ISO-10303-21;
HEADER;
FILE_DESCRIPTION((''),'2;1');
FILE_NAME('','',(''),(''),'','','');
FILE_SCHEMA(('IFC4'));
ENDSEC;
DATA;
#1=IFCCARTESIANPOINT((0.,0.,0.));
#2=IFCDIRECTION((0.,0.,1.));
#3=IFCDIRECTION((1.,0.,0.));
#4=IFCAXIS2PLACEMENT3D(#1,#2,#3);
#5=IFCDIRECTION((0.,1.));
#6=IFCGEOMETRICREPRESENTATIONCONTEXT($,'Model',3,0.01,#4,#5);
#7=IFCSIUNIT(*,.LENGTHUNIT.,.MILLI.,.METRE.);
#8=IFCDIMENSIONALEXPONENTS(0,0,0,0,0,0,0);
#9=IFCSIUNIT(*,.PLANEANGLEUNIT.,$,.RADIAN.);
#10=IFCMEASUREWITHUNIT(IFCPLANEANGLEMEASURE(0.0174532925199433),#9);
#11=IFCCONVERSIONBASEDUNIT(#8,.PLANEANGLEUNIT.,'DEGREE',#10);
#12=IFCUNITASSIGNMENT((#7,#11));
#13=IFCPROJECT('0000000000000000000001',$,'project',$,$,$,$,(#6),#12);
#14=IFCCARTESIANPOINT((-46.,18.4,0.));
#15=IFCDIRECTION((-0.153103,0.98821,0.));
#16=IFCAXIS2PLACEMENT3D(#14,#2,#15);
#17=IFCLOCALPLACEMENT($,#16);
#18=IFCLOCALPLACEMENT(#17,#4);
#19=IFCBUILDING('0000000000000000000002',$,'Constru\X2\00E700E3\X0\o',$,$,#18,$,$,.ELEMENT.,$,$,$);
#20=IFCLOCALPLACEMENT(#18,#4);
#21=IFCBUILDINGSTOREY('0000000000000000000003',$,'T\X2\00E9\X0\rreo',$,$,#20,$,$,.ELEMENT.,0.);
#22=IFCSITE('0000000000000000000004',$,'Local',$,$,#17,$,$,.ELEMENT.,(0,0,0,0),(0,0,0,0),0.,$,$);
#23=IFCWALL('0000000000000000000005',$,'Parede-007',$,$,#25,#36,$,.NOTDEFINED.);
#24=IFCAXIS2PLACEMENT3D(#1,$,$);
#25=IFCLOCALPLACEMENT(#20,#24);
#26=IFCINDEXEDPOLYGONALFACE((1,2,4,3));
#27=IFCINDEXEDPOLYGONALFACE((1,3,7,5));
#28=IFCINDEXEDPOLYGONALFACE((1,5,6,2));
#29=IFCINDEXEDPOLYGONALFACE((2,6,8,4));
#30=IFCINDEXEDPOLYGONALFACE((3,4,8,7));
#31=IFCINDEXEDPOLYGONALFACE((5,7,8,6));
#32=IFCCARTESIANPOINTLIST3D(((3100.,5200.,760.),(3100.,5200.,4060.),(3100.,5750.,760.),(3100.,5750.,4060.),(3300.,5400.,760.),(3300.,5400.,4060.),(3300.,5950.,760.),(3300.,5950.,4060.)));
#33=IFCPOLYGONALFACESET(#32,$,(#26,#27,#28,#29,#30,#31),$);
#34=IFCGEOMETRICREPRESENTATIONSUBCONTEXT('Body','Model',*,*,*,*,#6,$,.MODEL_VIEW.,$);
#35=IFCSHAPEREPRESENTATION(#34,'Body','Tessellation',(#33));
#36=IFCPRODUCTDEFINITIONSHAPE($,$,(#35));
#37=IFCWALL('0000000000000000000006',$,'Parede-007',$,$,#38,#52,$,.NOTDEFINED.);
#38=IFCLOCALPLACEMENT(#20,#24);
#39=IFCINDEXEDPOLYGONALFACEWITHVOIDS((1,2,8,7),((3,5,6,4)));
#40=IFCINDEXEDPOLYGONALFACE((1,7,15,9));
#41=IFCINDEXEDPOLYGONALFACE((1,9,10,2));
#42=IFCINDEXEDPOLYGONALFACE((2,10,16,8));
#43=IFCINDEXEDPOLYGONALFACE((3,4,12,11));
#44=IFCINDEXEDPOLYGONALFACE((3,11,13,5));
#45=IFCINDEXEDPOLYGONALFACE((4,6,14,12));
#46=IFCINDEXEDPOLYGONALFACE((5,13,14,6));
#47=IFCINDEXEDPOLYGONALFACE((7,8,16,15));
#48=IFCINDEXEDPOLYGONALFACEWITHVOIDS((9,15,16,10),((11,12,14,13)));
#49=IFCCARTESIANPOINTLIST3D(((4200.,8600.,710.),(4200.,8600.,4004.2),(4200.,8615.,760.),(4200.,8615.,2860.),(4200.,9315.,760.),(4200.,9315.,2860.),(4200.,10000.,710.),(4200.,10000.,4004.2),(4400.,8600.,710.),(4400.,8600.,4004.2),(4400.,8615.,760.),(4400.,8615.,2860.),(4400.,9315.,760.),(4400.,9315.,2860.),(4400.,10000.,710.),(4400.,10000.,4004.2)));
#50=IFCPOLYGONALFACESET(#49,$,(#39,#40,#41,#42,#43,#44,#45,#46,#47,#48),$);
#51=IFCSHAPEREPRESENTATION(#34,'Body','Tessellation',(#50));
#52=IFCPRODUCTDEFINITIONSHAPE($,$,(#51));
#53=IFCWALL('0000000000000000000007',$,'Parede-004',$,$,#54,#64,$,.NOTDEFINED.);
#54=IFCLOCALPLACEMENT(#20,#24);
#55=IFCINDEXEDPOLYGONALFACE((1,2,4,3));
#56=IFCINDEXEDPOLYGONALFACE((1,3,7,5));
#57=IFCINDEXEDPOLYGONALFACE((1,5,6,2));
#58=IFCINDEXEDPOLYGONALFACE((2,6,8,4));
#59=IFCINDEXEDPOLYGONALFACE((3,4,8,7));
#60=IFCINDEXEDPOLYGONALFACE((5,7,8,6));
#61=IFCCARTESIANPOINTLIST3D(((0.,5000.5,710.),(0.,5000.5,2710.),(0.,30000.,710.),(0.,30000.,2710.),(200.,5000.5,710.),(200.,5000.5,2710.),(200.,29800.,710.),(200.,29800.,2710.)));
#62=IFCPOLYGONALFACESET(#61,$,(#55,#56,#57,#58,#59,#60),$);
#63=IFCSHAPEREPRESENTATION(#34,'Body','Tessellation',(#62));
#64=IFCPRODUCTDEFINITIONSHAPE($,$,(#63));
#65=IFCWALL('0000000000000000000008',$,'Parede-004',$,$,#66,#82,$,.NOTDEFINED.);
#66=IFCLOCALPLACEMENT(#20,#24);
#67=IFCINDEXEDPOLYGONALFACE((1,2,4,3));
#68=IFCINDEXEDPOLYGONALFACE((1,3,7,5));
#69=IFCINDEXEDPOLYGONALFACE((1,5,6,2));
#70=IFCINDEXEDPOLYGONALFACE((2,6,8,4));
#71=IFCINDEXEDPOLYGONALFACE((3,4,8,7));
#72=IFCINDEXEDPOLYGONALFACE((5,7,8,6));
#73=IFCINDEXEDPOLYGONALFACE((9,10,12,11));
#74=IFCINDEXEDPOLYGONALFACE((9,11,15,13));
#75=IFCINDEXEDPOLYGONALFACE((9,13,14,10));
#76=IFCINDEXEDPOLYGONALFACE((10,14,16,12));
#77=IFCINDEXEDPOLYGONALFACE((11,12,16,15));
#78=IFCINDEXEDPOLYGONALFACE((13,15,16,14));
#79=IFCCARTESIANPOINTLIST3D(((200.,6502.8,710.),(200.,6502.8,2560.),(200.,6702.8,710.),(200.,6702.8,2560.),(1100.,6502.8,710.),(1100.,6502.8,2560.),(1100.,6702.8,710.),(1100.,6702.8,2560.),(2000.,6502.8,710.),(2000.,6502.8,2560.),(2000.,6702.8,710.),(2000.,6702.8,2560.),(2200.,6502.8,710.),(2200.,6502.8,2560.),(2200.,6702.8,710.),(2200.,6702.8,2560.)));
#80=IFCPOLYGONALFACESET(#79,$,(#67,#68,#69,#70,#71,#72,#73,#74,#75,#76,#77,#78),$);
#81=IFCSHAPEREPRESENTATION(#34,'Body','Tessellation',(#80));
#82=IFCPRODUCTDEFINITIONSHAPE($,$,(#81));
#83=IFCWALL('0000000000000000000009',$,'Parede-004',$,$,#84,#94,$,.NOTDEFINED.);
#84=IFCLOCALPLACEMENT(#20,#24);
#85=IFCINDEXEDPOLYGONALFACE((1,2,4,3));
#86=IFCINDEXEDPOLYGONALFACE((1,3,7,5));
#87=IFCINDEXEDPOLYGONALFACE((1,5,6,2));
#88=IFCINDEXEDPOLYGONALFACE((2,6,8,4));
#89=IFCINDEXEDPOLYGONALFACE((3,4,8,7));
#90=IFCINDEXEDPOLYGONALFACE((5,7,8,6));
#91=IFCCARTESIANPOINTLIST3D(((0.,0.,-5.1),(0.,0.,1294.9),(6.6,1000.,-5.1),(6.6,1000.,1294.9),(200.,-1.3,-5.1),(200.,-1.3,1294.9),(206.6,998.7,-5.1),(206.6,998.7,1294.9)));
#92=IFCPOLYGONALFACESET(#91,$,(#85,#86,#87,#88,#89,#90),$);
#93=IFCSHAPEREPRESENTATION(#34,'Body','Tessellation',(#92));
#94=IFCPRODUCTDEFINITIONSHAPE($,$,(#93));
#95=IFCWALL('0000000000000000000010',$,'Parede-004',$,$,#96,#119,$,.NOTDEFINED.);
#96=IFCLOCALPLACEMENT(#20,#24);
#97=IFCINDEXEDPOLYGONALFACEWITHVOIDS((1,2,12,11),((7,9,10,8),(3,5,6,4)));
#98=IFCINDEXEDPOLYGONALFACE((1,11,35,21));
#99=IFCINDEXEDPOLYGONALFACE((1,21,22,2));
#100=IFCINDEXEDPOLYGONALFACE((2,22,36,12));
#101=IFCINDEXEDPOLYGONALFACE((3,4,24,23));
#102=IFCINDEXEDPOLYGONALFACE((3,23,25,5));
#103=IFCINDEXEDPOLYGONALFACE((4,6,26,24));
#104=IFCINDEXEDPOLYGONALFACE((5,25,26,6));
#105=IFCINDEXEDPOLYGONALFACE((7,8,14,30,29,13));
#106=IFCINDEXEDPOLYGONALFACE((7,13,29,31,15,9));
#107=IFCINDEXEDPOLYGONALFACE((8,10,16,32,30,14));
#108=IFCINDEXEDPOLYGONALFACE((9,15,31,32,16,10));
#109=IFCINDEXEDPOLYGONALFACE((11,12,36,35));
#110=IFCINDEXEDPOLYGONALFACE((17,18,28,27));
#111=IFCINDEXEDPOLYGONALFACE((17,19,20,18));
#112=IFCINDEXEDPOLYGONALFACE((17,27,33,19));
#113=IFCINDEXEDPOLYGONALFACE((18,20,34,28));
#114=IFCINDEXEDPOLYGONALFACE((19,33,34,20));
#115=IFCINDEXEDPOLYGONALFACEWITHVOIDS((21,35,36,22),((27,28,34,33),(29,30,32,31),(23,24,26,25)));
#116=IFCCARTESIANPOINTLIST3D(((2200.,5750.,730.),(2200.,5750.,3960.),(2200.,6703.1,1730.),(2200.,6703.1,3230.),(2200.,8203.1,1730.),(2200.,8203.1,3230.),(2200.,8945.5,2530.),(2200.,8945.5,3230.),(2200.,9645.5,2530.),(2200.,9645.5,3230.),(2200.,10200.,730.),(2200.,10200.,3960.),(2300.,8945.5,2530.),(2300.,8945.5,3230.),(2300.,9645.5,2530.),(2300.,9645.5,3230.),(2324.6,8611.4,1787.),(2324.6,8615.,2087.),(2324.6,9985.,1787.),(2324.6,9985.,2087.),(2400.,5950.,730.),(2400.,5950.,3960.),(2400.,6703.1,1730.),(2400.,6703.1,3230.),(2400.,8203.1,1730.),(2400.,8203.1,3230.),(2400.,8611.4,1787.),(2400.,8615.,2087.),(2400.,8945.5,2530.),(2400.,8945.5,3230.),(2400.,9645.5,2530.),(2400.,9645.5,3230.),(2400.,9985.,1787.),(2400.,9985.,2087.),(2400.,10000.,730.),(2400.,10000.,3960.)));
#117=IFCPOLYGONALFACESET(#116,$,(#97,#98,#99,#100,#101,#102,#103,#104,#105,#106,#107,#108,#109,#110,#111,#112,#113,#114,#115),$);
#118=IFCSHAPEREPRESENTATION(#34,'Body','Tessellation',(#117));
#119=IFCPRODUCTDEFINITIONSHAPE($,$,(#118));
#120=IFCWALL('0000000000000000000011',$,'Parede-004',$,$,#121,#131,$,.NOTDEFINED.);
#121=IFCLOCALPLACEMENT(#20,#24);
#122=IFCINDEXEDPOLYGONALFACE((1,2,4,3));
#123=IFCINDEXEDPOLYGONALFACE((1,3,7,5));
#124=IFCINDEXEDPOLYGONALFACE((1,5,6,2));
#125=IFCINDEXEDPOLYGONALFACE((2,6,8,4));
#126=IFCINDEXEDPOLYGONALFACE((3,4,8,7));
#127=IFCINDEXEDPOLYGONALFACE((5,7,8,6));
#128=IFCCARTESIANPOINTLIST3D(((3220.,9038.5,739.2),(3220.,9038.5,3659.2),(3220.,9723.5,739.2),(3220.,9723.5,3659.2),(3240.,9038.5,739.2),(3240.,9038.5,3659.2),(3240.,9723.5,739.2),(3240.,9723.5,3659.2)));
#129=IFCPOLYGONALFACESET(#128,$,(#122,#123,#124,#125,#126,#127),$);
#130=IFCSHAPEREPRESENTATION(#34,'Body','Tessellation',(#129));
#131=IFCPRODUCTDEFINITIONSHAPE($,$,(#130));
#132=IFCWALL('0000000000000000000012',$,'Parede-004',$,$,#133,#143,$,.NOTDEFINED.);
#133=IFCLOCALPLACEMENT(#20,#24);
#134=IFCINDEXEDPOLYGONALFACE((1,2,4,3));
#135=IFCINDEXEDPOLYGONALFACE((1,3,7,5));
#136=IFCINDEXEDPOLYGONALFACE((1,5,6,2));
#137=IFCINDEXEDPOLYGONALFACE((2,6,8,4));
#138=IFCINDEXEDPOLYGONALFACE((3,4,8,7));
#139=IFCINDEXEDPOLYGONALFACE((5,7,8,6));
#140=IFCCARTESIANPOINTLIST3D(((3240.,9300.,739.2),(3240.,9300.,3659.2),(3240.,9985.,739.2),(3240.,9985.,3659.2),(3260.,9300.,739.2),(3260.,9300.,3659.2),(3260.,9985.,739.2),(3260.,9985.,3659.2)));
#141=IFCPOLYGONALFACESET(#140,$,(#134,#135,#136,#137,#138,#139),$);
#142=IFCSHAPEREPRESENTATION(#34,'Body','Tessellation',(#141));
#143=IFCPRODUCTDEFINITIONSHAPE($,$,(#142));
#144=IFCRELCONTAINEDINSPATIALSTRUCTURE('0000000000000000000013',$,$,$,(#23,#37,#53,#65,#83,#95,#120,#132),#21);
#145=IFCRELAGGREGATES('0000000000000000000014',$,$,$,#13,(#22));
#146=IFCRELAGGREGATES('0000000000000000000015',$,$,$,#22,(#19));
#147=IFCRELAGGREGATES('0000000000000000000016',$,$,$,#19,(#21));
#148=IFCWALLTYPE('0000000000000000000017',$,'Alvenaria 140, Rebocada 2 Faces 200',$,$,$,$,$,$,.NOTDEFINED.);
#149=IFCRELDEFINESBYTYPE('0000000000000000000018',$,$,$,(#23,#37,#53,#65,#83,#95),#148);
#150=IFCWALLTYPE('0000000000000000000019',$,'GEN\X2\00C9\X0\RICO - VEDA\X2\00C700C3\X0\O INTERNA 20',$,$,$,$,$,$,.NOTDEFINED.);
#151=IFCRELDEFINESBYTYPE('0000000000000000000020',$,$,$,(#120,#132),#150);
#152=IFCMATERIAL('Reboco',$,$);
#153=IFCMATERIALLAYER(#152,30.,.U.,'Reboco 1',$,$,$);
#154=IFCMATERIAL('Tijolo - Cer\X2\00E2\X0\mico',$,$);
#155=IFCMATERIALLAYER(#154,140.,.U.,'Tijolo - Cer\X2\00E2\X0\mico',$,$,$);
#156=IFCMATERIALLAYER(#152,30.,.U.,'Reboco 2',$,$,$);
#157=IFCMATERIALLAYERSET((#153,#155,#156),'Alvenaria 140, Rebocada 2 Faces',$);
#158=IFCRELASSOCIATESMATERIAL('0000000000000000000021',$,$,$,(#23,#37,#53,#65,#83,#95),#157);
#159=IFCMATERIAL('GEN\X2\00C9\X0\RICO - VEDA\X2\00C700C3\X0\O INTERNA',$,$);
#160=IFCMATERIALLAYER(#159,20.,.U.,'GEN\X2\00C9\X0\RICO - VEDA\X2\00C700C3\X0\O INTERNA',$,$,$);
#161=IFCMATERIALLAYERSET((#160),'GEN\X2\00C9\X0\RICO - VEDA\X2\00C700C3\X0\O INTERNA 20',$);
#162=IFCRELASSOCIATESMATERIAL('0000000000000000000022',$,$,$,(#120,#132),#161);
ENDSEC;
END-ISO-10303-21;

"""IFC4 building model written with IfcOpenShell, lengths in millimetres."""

from ifc_helpers import new_model, entity, si_unit, converted_unit, direction, frame, origin_with_axes, origin_2d_with_axis, place, context, subcontext, project, spatial, line, indexed_curve, rectangle, outline, extrude, material, layer, layer_set, layer_usage, type_object, element, save


model = new_model("IFC4")

# Units and contexts
model_context = context("Model", 3, precision=0.01, world=origin_with_axes(), true_north=direction((0.0, 1.0)))
body_context = subcontext(model_context, "Body", "Model", "MODEL_VIEW")
ifc_project = project(units=[si_unit("LENGTHUNIT", "METRE", prefix="MILLI"), converted_unit("PLANEANGLEUNIT", "DEGREE", entity("IfcPlaneAngleMeasure", 0.0174532925199433), si_unit("PLANEANGLEUNIT", "RADIAN"), dimensions=[0, 0, 0, 0, 0, 0, 0])], contexts=[model_context])

# Site, building, storey
site_placement = place(None, frame((-46.0, 18.4, 0.0), z_axis=(0.0, 0.0, 1.0), x_axis=(-0.153103, 0.98821, 0.0)))
site = spatial("IfcSite", under=ifc_project, at=site_placement, Name="Local", CompositionType="ELEMENT", RefLatitude=(0, 0, 0, 0), RefLongitude=(0, 0, 0, 0), RefElevation=0.0)
building_placement = place(site_placement, origin_with_axes())
building = spatial("IfcBuilding", under=site, at=building_placement, Name="Construção", CompositionType="ELEMENT")
storey_placement = place(building_placement, origin_with_axes())
storey = spatial("IfcBuildingStorey", under=building, at=storey_placement, Name="Térreo", CompositionType="ELEMENT", Elevation=0.0)

# Wall
ifc_material_1 = material(Name="Reboco")
ifc_layer_1 = layer(ifc_material_1, 30.0, ventilated="UNKNOWN", Name="Reboco 1")
ifc_material_2 = material(Name="Tijolo - Cerâmico")
ifc_layer_2 = layer(ifc_material_2, 140.0, ventilated="UNKNOWN", Name="Tijolo - Cerâmico")
ifc_layer_3 = layer(ifc_material_1, 30.0, ventilated="UNKNOWN", Name="Reboco 2")
ifc_layer_set_1 = layer_set([ifc_layer_1, ifc_layer_2, ifc_layer_3], Name="Alvenaria 140, Rebocada 2 Faces")
ifc_layer_usage_1 = layer_usage(ifc_layer_set_1, "AXIS2", "POSITIVE", 0.0)
wall_type_1 = type_object("IfcWallType", Name="Alvenaria 140, Rebocada 2 Faces 200", PredefinedType="NOTDEFINED")
wall_1_placement = place(storey_placement, frame((3300.0, 5200.0, 760.0), z_axis=(0.0, 0.0, 1.0), x_axis=(-0.000001, 1.0, 0.0)))
element("IfcWall", 1, at=wall_1_placement, inside=storey, type_object=wall_type_1, material=ifc_layer_usage_1, Name="Parede-007", PredefinedType="NOTDEFINED", context=body_context, shape_type="SweptSolid", body=[
    extrude(outline(indexed_curve([(200.0, 0.0), (750.0, 0.0), (550.0, 200.0), (0.0, 200.0)], segments=[line(1, 2, 3, 4, 1)])), origin_with_axes(), (0.0, 0.0, 1.0), 3300.0),
])

# Wall, opening
ifc_layer_usage_2 = layer_usage(ifc_layer_set_1, "AXIS2", "POSITIVE", 0.0)
wall_2_placement = place(storey_placement, frame((4400.0, 8600.0, 710.0), z_axis=(0.0, 0.0, 1.0), x_axis=(-0.000002, 1.0, 0.0)))
wall_2 = element("IfcWall", 2, at=wall_2_placement, inside=storey, type_object=wall_type_1, material=ifc_layer_usage_2, Name="Parede-007", PredefinedType="NOTDEFINED", context=body_context, shape_type="SweptSolid", body=[
    extrude(outline(indexed_curve([(0.0, 0.0), (1400.0, 0.0), (1400.0, 200.0), (0.0, 200.0)], segments=[line(1, 2, 3, 4, 1)])), origin_with_axes(), (0.0, 0.0, 1.0), 3294.2),
])
opening_1_placement = place(wall_2_placement, frame((365.0, 0.0, 50.0), z_axis=(0.0, 0.0, 1.0), x_axis=(1.0, 0.0, 0.0)))
element("IfcOpeningElement", 3, at=opening_1_placement, cuts=wall_2, context=body_context, shape_type="SweptSolid", body=[
    extrude(rectangle(XDim=700.0, YDim=2100.0, at=origin_2d_with_axis()), frame((0.0, 200.0, 1050.0), z_axis=(0.0, 1.0, 0.0), x_axis=(-1.0, 0.0, 0.0)), (0.0, 0.0, -1.0), 600.0),
])

# Wall
ifc_layer_usage_3 = layer_usage(ifc_layer_set_1, "AXIS2", "NEGATIVE", 0.0)
wall_3_placement = place(storey_placement, frame((0.0, 5000.5, 710.0), z_axis=(0.0, 0.0, 1.0), x_axis=(0.0, 1.0, 0.0)))
element("IfcWall", 4, at=wall_3_placement, inside=storey, type_object=wall_type_1, material=ifc_layer_usage_3, Name="Parede-004", PredefinedType="NOTDEFINED", context=body_context, shape_type="SweptSolid", body=[
    extrude(outline(indexed_curve([(0.0, -200.0), (24799.5, -200.0), (24999.5, 0.0), (0.0, 0.0)], segments=[line(1, 2, 3, 4, 1)])), origin_with_axes(), (0.0, 0.0, 1.0), 2000.0),
])

# Wall, opening
ifc_layer_usage_4 = layer_usage(ifc_layer_set_1, "AXIS2", "POSITIVE", 0.0)
wall_4_placement = place(storey_placement, frame((2200.0, 6702.8, 710.0), z_axis=(0.0, 0.0, 1.0), x_axis=(-1.0, 0.0, 0.0)))
wall_4 = element("IfcWall", 5, at=wall_4_placement, inside=storey, type_object=wall_type_1, material=ifc_layer_usage_4, Name="Parede-004", PredefinedType="NOTDEFINED", context=body_context, shape_type="SweptSolid", body=[
    extrude(outline(indexed_curve([(0.0, 0.0), (2000.0, 0.0), (2000.0, 200.0), (0.0, 200.0)], segments=[line(1, 2, 3, 4, 1)])), origin_with_axes(), (0.0, 0.0, 1.0), 1850.0),
])
opening_2_placement = place(wall_4_placement, frame((650.0, 0.0, 0.0), z_axis=(0.0, 0.0, 1.0), x_axis=(1.0, 0.0, 0.0)))
element("IfcOpeningElement", 6, at=opening_2_placement, cuts=wall_4, context=body_context, shape_type="SweptSolid", body=[
    extrude(rectangle(XDim=900.0, YDim=1850.0, at=origin_2d_with_axis()), frame((0.0, -200.0, 925.0), z_axis=(0.0, -1.0, 0.0), x_axis=(1.0, 0.0, 0.0)), (0.0, 0.0, -1.0), 600.0),
])

# Wall
ifc_layer_usage_5 = layer_usage(ifc_layer_set_1, "AXIS2", "POSITIVE", 0.0)
wall_5_placement = place(storey_placement, frame((200.0, -1.3, -5.1), z_axis=(0.0, 0.0, 1.0), x_axis=(0.006602, 0.999978, 0.0)))
element("IfcWall", 7, at=wall_5_placement, inside=storey, type_object=wall_type_1, material=ifc_layer_usage_5, Name="Parede-004", PredefinedType="NOTDEFINED", context=body_context, shape_type="SweptSolid", body=[
    extrude(outline(indexed_curve([(0.0, 0.0), (1000.0, 0.0), (1000.0, 200.0), (0.0, 200.0)], segments=[line(1, 2, 3, 4, 1)])), origin_with_axes(), (0.0, 0.0, 1.0), 1300.0),
])

# Wall, openings
ifc_layer_usage_6 = layer_usage(ifc_layer_set_1, "AXIS2", "NEGATIVE", 0.0)
wall_6_placement = place(storey_placement, frame((2200.0, 5750.0, 730.0), z_axis=(0.0, 0.0, 1.0), x_axis=(0.0, 1.0, 0.0)))
wall_6 = element("IfcWall", 8, at=wall_6_placement, inside=storey, type_object=wall_type_1, material=ifc_layer_usage_6, Name="Parede-004", PredefinedType="NOTDEFINED", context=body_context, shape_type="SweptSolid", body=[
    extrude(outline(indexed_curve([(200.0, -200.0), (4250.0, -200.0), (4450.0, 0.0), (0.0, 0.0)], segments=[line(1, 2, 3, 4, 1)])), origin_with_axes(), (0.0, 0.0, 1.0), 3230.0),
])
opening_3_placement = place(wall_6_placement, frame((3545.5, 0.0, 1800.0), z_axis=(0.0, 0.0, 1.0), x_axis=(1.0, 0.0, 0.0)))
element("IfcOpeningElement", 9, at=opening_3_placement, cuts=wall_6, context=body_context, shape_type="SweptSolid", body=[
    extrude(rectangle(XDim=700.0, YDim=700.0, at=origin_2d_with_axis()), frame((0.0, -100.0, 350.0), z_axis=(0.0, -1.0, 0.0), x_axis=(-1.0, 0.0, 0.0)), (0.0, 0.0, -1.0), 300.0),
    extrude(rectangle(XDim=700.0, YDim=700.0, at=origin_2d_with_axis()), frame((0.0, -100.0, 350.0), z_axis=(0.0, 1.0, 0.0), x_axis=(-1.0, 0.0, 0.0)), (0.0, 0.0, -1.0), 300.0),
])
opening_4_placement = place(wall_6_placement, frame((1703.1, 0.0, 1000.0), z_axis=(0.0, 0.0, 1.0), x_axis=(1.0, 0.0, 0.0)))
element("IfcOpeningElement", 10, at=opening_4_placement, cuts=wall_6, context=body_context, shape_type="SweptSolid", body=[
    extrude(rectangle(XDim=1500.0, YDim=1500.0, at=origin_2d_with_axis()), frame((0.0, -200.0, 750.0), z_axis=(0.0, 1.0, 0.0), x_axis=(1.0, 0.0, 0.0)), (0.0, 0.0, 1.0), 400.0),
    extrude(rectangle(XDim=1500.0, YDim=1500.0, at=origin_2d_with_axis()), frame((0.0, -200.0, 750.0), z_axis=(0.0, -1.0, 0.0), x_axis=(1.0, 0.0, 0.0)), (0.0, 0.0, 1.0), 400.0),
])
opening_5_placement = place(wall_6_placement, frame((-5750.0, 2200.0, -730.0), z_axis=(0.0, 0.0, 1.0), x_axis=(0.0, -1.0, 0.0)))
element("IfcOpeningElement", 11, at=opening_5_placement, cuts=wall_6, PredefinedType="OPENING", context=body_context, shape_type="SweptSolid", body=[
    extrude(outline(indexed_curve([(-686.8, -150.0), (686.8, -150.0), (686.8, 150.0), (-683.2, 150.0)], segments=[line(1, 2, 3, 4, 1)])), frame((2324.6, 9298.2, 1937.0), z_axis=(1.0, 0.0, 0.0), x_axis=(0.0, 1.0, 0.0)), (0.0, 0.0, 1.0), 275.4),
])

# Walls
ifc_material_3 = material(Name="GENÉRICO - VEDAÇÃO INTERNA")
ifc_layer_4 = layer(ifc_material_3, 20.0, ventilated="UNKNOWN", Name="GENÉRICO - VEDAÇÃO INTERNA")
ifc_layer_set_2 = layer_set([ifc_layer_4], Name="GENÉRICO - VEDAÇÃO INTERNA 20")
ifc_layer_usage_7 = layer_usage(ifc_layer_set_2, "AXIS2", "POSITIVE", -20.0)
wall_type_2 = type_object("IfcWallType", Name="GENÉRICO - VEDAÇÃO INTERNA 20", PredefinedType="NOTDEFINED")
wall_7_placement = place(storey_placement, frame((3220.0, 9038.5, 739.2), z_axis=(0.0, 0.0, 1.0), x_axis=(0.0, 1.0, 0.0)))
element("IfcWall", 12, at=wall_7_placement, inside=storey, type_object=wall_type_2, material=ifc_layer_usage_7, Name="Parede-004", PredefinedType="NOTDEFINED", context=body_context, shape_type="SweptSolid", body=[
    extrude(outline(indexed_curve([(0.0, -20.0), (685.0, -20.0), (685.0, 0.0), (0.0, 0.0)], segments=[line(1, 2, 3, 4, 1)])), origin_with_axes(), (0.0, 0.0, 1.0), 2920.0),
])
ifc_layer_usage_8 = layer_usage(ifc_layer_set_2, "AXIS2", "POSITIVE", -20.0)
wall_8_placement = place(storey_placement, frame((3240.0, 9300.0, 739.2), z_axis=(0.0, 0.0, 1.0), x_axis=(0.0, 1.0, 0.0)))
element("IfcWall", 13, at=wall_8_placement, inside=storey, type_object=wall_type_2, material=ifc_layer_usage_8, Name="Parede-004", PredefinedType="NOTDEFINED", context=body_context, shape_type="SweptSolid", body=[
    extrude(outline(indexed_curve([(0.0, -20.0), (685.0, -20.0), (685.0, 0.0), (0.0, 0.0)], segments=[line(1, 2, 3, 4, 1)])), origin_with_axes(), (0.0, 0.0, 1.0), 2920.0),
])

save(model, "model.ifc")
